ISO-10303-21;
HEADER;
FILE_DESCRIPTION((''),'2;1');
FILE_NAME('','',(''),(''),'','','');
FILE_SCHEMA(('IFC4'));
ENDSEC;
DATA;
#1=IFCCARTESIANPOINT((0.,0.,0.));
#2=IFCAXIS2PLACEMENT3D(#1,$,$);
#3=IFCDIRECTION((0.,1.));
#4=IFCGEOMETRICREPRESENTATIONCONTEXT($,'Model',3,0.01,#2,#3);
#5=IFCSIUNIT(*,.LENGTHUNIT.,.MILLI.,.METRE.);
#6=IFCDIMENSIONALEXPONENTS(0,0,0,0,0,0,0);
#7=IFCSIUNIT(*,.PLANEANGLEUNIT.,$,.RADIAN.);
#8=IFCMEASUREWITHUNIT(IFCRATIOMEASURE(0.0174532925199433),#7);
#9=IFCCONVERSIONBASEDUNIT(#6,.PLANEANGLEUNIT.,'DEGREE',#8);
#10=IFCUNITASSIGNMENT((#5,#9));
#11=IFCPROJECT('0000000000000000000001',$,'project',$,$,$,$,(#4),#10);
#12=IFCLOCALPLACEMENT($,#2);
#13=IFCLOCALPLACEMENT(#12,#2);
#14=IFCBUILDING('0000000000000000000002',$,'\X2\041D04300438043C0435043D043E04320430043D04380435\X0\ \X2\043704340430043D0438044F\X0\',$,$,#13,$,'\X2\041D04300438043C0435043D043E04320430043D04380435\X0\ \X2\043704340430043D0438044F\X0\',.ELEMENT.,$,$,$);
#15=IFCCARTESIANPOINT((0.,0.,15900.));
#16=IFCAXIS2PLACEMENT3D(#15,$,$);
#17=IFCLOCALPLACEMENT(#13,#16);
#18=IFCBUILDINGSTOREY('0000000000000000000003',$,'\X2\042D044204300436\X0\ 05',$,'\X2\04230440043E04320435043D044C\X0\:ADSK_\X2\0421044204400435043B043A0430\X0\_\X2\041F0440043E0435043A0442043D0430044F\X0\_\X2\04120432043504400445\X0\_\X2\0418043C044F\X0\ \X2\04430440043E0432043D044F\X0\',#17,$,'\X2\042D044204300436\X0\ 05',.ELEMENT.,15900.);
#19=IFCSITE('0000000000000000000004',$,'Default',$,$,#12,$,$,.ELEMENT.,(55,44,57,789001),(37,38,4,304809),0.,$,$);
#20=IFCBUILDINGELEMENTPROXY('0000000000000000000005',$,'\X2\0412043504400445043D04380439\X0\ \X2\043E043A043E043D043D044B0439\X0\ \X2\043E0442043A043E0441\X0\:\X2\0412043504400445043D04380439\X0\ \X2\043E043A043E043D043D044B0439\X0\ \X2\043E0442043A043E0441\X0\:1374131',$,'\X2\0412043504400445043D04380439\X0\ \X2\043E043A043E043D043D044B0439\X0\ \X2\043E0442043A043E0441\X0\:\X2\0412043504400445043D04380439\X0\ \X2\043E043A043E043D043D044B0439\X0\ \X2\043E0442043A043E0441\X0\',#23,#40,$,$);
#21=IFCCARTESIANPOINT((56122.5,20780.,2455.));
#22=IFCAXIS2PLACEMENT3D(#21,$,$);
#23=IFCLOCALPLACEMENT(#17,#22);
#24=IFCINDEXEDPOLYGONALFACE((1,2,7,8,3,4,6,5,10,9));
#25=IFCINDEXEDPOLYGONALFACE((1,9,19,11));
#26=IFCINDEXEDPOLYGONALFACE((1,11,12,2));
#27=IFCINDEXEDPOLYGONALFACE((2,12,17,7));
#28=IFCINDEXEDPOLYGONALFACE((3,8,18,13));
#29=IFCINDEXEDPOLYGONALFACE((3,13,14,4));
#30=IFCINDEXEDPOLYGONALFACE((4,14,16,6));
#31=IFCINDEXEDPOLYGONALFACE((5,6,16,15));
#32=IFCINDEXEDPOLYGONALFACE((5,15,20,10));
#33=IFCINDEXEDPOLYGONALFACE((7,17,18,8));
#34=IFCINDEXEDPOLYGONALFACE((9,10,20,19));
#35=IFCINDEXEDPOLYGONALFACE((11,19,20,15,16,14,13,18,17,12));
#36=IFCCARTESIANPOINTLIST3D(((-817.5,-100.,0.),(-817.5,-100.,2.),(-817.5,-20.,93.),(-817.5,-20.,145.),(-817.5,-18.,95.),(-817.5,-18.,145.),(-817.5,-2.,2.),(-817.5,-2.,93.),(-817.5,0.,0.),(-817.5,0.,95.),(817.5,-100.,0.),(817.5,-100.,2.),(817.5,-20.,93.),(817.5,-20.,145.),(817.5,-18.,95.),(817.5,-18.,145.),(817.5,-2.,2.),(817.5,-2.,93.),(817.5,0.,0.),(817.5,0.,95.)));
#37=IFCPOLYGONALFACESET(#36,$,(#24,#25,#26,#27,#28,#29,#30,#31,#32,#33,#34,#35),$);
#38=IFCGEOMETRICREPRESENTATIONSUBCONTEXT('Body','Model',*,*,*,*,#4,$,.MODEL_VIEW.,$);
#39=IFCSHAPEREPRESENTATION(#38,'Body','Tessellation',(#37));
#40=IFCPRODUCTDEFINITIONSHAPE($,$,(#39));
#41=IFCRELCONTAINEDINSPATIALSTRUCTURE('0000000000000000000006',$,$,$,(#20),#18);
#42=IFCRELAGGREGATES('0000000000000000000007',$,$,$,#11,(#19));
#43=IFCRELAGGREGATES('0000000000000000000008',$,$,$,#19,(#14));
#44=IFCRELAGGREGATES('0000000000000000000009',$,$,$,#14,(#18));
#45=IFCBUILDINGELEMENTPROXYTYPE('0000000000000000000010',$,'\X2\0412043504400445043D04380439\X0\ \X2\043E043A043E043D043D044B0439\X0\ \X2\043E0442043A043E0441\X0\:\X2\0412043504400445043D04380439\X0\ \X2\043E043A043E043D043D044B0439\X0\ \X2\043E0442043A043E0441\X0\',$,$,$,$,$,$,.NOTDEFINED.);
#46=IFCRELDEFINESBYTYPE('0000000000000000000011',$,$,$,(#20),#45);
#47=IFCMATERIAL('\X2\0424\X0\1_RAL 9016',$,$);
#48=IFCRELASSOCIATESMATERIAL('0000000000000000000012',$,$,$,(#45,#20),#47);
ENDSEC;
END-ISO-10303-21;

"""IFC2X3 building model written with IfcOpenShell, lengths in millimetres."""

from ifc_helpers import new_model, entity, si_unit, converted_unit, direction, frame, origin, place, context, subcontext, project, spatial, polyline, outline, extrude, source, transform, mapped, material, type_object, type_shapes, element, save


model = new_model("IFC2X3")

# Units and contexts
model_context = context("Model", 3, precision=0.01, world=origin(), true_north=direction((0.0, 1.0)))
body_context = subcontext(model_context, "Body", "Model", "MODEL_VIEW")
ifc_project = project(units=[si_unit("LENGTHUNIT", "METRE", prefix="MILLI"), converted_unit("PLANEANGLEUNIT", "DEGREE", entity("IfcRatioMeasure", 0.0174532925199433), si_unit("PLANEANGLEUNIT", "RADIAN"), dimensions=[0, 0, 0, 0, 0, 0, 0])], contexts=[model_context])

# Site, building, storey
site_placement = place(None, origin())
site = spatial("IfcSite", under=ifc_project, at=site_placement, Name="Default", CompositionType="ELEMENT", RefLatitude=(55, 44, 57, 789001), RefLongitude=(37, 38, 4, 304809), RefElevation=0.0)
building_placement = place(site_placement, origin())
building = spatial("IfcBuilding", under=site, at=building_placement, Name="Наименование здания", LongName="Наименование здания", CompositionType="ELEMENT")
storey_placement = place(building_placement, frame((0.0, 0.0, 15900.0)))
storey = spatial("IfcBuildingStorey", under=building, at=storey_placement, Name="Этаж 05", ObjectType="Уровень:ADSK_Стрелка_Проектная_Вверх_Имя уровня", LongName="Этаж 05", CompositionType="ELEMENT", Elevation=15900.0)

# Building element proxy
ifc_material_1 = material(Name="Ф1_RAL 9016")
building_element_proxy_type_1 = type_object("IfcBuildingElementProxyType", Name="Верхний оконный откос:Верхний оконный откос", PredefinedType="NOTDEFINED", material=ifc_material_1)
shared_shape_1 = source(origin(), body_context, "Body", "SweptSolid", [
    extrude(outline(polyline([(28.0, -10.0), (78.0, -10.0), (78.0, -8.0), (26.0, -8.0), (26.0, -26.0), (-65.0, -26.0), (-65.0, 72.0), (-67.0, 72.0), (-67.0, -28.0), (28.0, -28.0), (28.0, -10.0)])), frame((-817.5, -28.0, 67.0), z_axis=(1.0, 0.0, 0.0), x_axis=(0.0, 0.0, 1.0)), (0.0, 0.0, 1.0), 1635.0),
])
type_shapes(building_element_proxy_type_1, [shared_shape_1])
proxy_1_placement = place(storey_placement, frame((56122.5, 20780.0, 2455.0)))
element("IfcBuildingElementProxy", 1, at=proxy_1_placement, inside=storey, type_object=building_element_proxy_type_1, material=ifc_material_1, Name="Верхний оконный откос:Верхний оконный откос:1374131", ObjectType="Верхний оконный откос:Верхний оконный откос", context=body_context, shape_type="MappedRepresentation", body=[
    mapped(shared_shape_1, transform((0.0, 0.0, 0.0), scale=1.0)),
])

save(model, "model.ifc")
